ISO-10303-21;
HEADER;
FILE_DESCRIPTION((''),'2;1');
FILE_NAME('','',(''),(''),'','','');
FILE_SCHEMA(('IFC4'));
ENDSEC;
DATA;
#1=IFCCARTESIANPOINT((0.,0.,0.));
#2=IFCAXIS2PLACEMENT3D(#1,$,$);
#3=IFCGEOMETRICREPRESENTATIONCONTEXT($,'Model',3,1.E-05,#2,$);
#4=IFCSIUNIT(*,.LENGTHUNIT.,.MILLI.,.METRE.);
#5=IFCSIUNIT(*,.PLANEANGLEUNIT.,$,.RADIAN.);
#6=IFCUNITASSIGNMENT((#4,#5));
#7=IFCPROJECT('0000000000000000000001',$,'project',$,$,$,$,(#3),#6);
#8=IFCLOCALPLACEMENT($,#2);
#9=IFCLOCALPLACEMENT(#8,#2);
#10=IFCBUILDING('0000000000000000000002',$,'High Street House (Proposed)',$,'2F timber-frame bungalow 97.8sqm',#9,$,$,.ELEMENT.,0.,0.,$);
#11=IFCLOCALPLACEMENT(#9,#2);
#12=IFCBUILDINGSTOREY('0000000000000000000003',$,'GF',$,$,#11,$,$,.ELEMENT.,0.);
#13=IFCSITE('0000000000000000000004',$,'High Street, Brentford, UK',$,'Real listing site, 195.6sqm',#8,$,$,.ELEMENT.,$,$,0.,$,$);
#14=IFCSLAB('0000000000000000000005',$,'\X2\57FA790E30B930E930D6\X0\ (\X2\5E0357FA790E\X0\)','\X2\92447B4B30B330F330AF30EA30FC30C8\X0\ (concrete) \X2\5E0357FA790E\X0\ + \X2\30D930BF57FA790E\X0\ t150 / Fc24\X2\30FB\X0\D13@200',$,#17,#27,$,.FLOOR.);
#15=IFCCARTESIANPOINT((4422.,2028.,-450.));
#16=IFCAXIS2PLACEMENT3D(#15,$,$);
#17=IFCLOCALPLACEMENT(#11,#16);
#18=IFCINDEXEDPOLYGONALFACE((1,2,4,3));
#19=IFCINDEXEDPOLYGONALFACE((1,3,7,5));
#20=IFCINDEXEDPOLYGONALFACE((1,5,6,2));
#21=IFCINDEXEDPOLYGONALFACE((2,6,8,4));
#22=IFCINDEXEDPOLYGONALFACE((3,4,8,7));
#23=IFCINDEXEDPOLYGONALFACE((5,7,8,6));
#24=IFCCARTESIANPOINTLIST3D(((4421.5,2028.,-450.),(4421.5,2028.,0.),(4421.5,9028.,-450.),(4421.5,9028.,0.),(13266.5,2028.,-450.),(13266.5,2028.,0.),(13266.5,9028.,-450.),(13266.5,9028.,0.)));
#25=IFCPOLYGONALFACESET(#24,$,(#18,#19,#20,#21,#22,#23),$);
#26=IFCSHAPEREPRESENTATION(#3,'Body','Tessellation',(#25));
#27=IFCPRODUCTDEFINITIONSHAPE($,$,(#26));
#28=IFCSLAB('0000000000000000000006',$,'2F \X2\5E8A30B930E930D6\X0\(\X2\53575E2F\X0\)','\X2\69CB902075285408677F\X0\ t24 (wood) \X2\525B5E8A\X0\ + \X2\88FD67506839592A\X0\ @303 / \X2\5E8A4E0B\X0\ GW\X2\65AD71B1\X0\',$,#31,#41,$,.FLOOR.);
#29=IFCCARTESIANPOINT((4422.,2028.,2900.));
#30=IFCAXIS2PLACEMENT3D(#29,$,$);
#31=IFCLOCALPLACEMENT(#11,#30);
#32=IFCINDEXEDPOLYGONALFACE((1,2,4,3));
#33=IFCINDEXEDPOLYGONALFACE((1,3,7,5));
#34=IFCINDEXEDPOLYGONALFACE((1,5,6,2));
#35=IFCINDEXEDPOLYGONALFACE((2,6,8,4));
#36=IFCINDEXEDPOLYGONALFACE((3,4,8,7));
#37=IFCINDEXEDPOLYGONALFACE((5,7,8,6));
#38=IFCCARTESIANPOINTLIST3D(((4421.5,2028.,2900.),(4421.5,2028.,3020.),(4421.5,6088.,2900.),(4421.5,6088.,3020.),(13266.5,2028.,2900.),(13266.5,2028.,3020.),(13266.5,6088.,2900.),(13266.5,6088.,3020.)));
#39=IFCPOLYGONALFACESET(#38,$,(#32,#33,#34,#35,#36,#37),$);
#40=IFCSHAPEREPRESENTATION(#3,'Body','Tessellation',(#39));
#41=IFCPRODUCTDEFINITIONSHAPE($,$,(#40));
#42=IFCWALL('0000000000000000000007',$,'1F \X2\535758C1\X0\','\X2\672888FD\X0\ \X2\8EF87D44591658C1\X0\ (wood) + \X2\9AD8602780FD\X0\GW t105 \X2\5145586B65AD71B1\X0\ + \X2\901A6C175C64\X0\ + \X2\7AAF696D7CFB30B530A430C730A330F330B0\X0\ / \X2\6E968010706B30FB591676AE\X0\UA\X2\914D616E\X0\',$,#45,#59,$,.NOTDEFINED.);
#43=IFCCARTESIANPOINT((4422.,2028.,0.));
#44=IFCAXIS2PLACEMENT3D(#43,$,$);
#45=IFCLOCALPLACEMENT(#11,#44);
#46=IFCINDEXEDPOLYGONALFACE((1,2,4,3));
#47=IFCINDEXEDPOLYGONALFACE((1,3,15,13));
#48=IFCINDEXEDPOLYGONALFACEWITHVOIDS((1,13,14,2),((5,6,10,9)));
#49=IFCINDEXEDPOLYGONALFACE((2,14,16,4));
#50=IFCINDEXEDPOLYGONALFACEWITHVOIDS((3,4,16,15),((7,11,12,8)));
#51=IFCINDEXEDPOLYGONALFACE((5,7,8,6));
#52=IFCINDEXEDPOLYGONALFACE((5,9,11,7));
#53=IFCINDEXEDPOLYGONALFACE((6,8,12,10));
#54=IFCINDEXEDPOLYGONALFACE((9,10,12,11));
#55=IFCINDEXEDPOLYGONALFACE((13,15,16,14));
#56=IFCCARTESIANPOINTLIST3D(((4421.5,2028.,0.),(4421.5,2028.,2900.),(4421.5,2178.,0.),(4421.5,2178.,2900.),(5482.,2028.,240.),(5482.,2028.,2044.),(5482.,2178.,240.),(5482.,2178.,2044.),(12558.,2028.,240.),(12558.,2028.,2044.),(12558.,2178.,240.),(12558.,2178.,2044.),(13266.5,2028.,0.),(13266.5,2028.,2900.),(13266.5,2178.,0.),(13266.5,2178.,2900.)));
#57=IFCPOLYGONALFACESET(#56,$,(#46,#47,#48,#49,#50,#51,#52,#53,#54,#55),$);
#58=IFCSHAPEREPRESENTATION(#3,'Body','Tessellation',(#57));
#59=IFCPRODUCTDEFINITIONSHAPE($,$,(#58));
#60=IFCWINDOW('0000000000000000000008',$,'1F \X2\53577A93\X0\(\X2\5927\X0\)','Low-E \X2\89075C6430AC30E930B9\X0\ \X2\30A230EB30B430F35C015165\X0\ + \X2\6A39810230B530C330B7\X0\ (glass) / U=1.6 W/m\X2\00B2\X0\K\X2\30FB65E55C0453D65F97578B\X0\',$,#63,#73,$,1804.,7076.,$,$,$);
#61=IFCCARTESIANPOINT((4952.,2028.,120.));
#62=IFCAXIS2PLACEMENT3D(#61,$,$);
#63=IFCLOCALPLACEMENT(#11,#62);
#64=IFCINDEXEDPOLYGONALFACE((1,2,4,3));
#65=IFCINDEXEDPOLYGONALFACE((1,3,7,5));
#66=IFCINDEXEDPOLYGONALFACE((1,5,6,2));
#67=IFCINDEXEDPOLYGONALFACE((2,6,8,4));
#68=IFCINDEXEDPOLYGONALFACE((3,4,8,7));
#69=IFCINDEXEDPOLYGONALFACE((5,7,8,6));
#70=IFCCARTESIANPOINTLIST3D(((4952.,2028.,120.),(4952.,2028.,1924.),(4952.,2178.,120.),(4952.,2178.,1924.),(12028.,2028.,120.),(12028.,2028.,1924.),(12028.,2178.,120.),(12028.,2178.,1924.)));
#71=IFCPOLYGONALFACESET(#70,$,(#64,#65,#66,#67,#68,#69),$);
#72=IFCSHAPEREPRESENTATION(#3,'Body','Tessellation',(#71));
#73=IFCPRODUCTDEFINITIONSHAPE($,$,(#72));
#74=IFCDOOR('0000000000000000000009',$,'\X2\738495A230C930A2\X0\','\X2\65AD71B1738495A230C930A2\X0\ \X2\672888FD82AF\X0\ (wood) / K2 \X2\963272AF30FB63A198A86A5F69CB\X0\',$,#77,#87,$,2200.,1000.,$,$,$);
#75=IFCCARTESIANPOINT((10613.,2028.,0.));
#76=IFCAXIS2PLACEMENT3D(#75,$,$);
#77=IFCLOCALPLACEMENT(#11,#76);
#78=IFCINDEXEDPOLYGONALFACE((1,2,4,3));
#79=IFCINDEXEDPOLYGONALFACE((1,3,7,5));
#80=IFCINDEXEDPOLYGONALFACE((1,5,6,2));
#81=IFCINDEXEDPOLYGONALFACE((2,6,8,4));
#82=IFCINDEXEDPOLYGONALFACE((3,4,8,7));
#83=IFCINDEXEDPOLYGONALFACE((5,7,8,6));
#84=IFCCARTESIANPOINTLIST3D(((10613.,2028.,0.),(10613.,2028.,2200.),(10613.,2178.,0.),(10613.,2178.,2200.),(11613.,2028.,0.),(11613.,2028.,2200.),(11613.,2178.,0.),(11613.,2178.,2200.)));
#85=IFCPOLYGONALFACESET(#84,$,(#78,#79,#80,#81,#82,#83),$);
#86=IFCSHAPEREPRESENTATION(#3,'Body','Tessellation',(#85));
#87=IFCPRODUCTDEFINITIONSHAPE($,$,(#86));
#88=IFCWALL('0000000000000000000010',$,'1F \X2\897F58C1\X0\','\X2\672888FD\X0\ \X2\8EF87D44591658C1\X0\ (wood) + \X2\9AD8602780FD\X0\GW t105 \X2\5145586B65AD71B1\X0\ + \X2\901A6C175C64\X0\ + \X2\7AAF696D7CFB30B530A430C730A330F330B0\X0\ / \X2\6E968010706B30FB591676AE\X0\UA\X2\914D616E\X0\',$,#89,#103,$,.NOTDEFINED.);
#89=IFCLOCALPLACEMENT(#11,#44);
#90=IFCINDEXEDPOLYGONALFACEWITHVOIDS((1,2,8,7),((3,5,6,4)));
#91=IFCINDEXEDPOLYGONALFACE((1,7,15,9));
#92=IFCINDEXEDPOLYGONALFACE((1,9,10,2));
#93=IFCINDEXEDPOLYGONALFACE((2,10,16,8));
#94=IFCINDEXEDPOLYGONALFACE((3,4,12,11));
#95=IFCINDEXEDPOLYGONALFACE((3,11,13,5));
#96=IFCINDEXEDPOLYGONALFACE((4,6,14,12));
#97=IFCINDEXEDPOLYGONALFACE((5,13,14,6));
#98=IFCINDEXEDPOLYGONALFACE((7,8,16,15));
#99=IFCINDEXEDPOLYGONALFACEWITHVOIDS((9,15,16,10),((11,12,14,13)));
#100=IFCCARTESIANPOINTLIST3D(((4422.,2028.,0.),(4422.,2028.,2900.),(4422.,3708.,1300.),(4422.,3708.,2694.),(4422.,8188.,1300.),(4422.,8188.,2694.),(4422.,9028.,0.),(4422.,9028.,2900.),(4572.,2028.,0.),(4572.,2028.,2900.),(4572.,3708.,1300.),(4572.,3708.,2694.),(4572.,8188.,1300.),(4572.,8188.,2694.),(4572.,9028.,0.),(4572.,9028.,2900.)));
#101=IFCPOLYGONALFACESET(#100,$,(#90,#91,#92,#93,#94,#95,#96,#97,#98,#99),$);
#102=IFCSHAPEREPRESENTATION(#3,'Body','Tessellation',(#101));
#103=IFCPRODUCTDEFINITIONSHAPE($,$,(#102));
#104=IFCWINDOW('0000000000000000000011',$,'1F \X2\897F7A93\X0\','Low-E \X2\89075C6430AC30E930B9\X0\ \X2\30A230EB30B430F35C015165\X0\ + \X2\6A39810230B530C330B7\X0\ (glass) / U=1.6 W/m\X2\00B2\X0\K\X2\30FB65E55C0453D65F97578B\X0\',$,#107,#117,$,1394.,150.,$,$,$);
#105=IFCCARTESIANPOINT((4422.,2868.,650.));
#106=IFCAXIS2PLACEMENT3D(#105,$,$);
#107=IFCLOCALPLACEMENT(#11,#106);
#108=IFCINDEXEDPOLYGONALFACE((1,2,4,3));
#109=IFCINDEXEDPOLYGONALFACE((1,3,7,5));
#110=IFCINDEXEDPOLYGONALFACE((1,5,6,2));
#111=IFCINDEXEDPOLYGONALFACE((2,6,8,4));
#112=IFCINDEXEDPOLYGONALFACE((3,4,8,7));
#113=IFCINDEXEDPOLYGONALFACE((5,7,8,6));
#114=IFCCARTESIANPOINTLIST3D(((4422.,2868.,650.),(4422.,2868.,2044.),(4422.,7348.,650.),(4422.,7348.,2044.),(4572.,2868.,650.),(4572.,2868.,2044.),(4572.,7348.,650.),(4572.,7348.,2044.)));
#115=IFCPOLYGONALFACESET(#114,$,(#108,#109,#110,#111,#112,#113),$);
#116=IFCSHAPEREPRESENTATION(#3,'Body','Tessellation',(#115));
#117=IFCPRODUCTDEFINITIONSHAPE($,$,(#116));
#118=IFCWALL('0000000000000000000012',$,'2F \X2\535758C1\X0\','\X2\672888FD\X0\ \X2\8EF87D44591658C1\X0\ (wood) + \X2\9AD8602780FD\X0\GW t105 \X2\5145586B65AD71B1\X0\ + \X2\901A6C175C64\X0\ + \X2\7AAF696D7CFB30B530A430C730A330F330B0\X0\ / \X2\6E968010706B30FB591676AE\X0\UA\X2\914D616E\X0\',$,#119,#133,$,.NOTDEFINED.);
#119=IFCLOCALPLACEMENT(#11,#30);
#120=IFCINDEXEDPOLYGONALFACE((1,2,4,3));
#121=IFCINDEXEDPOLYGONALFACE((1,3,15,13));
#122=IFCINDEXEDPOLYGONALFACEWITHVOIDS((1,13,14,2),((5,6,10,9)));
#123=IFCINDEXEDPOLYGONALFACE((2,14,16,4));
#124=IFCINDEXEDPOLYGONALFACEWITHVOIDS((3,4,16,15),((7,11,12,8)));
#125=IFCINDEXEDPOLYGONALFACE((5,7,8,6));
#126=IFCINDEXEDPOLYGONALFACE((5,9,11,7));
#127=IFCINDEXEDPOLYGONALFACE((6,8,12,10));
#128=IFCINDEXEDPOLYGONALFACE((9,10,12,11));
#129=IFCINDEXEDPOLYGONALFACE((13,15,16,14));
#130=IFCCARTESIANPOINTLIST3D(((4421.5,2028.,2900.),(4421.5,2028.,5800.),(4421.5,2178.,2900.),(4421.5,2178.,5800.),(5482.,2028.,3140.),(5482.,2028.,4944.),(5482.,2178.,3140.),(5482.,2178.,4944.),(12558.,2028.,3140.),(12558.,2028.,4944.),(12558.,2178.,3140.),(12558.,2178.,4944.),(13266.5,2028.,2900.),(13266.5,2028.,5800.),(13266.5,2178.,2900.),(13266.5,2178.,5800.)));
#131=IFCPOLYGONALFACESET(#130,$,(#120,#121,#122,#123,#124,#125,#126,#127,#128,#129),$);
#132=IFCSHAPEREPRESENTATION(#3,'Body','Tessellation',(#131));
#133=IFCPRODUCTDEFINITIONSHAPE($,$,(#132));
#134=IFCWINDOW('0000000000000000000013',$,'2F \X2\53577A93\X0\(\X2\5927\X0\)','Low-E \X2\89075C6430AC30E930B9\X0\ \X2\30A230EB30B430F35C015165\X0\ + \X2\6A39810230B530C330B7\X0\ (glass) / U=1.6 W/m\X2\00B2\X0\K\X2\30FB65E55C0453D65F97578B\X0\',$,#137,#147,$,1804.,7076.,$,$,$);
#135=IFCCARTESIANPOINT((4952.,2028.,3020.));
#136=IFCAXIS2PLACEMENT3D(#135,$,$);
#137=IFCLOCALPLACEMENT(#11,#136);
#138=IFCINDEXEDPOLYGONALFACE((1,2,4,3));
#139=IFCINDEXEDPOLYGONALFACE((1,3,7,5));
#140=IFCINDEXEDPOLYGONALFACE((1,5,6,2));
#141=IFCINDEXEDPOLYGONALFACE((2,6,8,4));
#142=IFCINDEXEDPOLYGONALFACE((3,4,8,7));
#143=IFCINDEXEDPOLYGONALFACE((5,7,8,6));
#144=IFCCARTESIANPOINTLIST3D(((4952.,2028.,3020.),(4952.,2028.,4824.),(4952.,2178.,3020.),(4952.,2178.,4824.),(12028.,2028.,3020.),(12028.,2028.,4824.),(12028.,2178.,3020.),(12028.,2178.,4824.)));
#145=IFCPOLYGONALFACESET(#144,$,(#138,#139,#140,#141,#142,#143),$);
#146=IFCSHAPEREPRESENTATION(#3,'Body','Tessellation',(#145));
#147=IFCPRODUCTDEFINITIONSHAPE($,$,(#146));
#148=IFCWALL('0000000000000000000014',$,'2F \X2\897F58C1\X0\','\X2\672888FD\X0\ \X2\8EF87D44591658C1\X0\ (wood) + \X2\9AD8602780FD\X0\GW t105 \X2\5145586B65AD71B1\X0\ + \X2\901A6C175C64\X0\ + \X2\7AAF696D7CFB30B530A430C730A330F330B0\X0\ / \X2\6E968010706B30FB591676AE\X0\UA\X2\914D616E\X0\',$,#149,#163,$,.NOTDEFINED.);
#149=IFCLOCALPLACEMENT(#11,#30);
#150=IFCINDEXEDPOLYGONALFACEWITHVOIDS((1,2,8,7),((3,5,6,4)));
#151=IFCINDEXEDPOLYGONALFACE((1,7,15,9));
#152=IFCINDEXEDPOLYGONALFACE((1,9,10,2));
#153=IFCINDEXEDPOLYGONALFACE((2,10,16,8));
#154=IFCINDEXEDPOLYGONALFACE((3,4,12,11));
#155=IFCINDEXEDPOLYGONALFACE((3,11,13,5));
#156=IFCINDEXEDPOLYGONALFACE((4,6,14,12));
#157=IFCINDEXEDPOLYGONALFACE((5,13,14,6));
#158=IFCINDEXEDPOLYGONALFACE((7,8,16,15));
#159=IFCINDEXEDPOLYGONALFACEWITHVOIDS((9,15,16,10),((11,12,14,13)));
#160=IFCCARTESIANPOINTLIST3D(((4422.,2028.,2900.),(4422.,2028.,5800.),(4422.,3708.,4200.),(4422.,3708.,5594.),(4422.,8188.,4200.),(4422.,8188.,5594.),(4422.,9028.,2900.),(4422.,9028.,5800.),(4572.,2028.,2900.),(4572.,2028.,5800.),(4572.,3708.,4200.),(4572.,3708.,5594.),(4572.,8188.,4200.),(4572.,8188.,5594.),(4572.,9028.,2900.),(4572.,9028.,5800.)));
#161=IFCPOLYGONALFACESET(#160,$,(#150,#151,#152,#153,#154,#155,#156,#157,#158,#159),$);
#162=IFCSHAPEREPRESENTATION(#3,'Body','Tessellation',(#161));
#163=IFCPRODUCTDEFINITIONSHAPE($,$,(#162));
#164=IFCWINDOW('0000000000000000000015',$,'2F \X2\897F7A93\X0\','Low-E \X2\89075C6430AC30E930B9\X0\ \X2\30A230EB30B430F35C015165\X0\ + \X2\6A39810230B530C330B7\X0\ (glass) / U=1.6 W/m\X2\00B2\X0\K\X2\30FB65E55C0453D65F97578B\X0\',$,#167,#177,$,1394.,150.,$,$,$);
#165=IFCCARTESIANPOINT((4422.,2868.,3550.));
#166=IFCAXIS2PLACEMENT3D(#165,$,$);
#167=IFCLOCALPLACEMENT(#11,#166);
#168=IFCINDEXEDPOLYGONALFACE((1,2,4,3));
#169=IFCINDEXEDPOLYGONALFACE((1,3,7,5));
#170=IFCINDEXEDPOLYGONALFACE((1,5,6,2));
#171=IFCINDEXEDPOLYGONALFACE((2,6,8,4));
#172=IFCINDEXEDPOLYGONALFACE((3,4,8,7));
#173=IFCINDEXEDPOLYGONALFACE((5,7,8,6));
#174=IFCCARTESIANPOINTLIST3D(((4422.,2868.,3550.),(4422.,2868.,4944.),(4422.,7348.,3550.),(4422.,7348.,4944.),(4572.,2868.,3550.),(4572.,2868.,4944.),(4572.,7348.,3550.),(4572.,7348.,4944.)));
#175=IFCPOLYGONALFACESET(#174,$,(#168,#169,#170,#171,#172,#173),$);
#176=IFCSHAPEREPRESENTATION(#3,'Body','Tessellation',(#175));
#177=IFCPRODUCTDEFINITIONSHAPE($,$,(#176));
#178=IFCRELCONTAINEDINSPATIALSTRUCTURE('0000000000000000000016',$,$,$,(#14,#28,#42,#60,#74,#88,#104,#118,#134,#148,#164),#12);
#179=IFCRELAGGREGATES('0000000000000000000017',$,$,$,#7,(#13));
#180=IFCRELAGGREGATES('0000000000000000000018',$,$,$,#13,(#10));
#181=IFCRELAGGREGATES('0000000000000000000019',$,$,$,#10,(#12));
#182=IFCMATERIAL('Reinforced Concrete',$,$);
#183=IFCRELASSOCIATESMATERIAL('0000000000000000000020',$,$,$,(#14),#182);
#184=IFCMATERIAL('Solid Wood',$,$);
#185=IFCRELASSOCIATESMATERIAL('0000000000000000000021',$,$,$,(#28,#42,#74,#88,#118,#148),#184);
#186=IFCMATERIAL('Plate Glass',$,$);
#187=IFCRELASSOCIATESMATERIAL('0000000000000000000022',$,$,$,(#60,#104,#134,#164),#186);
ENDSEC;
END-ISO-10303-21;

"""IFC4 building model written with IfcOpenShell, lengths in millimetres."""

from ifc_helpers import new_model, si_unit, frame, frame_2d, origin, place, context, project, spatial, rectangle, extrude, material, element, fill, save


model = new_model("IFC4")

# Units and contexts
model_context = context("Model", 3, precision=1e-05, world=origin())
ifc_project = project(units=[si_unit("LENGTHUNIT", "METRE", prefix="MILLI"), si_unit("PLANEANGLEUNIT", "RADIAN")], contexts=[model_context])

# Site, building, storey
site_placement = place(None, origin())
site = spatial("IfcSite", under=ifc_project, at=site_placement, Name="High Street, Brentford, UK", ObjectType="Real listing site, 195.6sqm", CompositionType="ELEMENT", RefElevation=0.0)
building_placement = place(site_placement, origin())
building = spatial("IfcBuilding", under=site, at=building_placement, Name="High Street House (Proposed)", ObjectType="2F timber-frame bungalow 97.8sqm", CompositionType="ELEMENT", ElevationOfRefHeight=0.0, ElevationOfTerrain=0.0)
storey_placement = place(building_placement, origin())
storey = spatial("IfcBuildingStorey", under=building, at=storey_placement, Name="GF", CompositionType="ELEMENT", Elevation=0.0)

# Slabs
ifc_material_1 = material(Name="Reinforced Concrete")
slab_1_placement = place(storey_placement, frame((4422.0, 2028.0, -450.0)))
element("IfcSlab", 1, at=slab_1_placement, inside=storey, material=ifc_material_1, Name="基礎スラブ (布基礎)", Description="鉄筋コンクリート (concrete) 布基礎 + ベタ基礎 t150 / Fc24・D13@200", PredefinedType="FLOOR", context=model_context, shape_type="SweptSolid", body=[
    extrude(rectangle(XDim=8845.0, YDim=7000.0, at=frame_2d((4422.0, 3500.0))), frame((4422.0, 2028.0, -450.0)), (0.0, 0.0, 1.0), 450.0),
])
ifc_material_2 = material(Name="Solid Wood")
slab_2_placement = place(storey_placement, frame((4422.0, 2028.0, 2900.0)))
element("IfcSlab", 2, at=slab_2_placement, inside=storey, material=ifc_material_2, Name="2F 床スラブ(南帯)", Description="構造用合板 t24 (wood) 剛床 + 製材根太 @303 / 床下 GW断熱", PredefinedType="FLOOR", context=model_context, shape_type="SweptSolid", body=[
    extrude(rectangle(XDim=8845.0, YDim=4060.0, at=frame_2d((4422.0, 2030.0))), frame((4422.0, 2028.0, 2900.0)), (0.0, 0.0, 1.0), 120.0),
])

# Wall, openings, window, door
wall_1_placement = place(storey_placement, frame((4422.0, 2028.0, 0.0)))
wall_1 = element("IfcWall", 3, at=wall_1_placement, inside=storey, material=ifc_material_2, Name="1F 南壁", Description="木製 軸組外壁 (wood) + 高性能GW t105 充填断熱 + 通気層 + 窯業系サイディング / 準耐火・外皮UA配慮", PredefinedType="NOTDEFINED", context=model_context, shape_type="SweptSolid", body=[
    extrude(rectangle(XDim=8845.0, YDim=150.0, at=frame_2d((4422.0, 75.0))), frame((4422.0, 2028.0, 0.0)), (0.0, 0.0, 1.0), 2900.0),
])
opening_1_placement = place(storey_placement, frame((4952.0, 2028.0, 120.0)))
opening_1 = element("IfcOpeningElement", 4, at=opening_1_placement, cuts=wall_1, PredefinedType="NOTDEFINED", context=model_context, shape_type="SweptSolid", body=[
    extrude(rectangle(XDim=7076.0, YDim=150.0, at=frame_2d((3538.0, 75.0))), frame((4952.0, 2028.0, 120.0)), (0.0, 0.0, 1.0), 1804.0),
])
opening_2_placement = place(storey_placement, frame((10613.0, 2028.0, 0.0)))
opening_2 = element("IfcOpeningElement", 5, at=opening_2_placement, cuts=wall_1, PredefinedType="NOTDEFINED", context=model_context, shape_type="SweptSolid", body=[
    extrude(rectangle(XDim=1000.0, YDim=150.0, at=frame_2d((500.0, 75.0))), frame((10613.0, 2028.0, 0.0)), (0.0, 0.0, 1.0), 2200.0),
])
ifc_material_3 = material(Name="Plate Glass")
window_1_placement = place(storey_placement, frame((4952.0, 2028.0, 120.0)))
window_1 = element("IfcWindow", 6, at=window_1_placement, inside=storey, material=ifc_material_3, Name="1F 南窓(大)", Description="Low-E 複層ガラス アルゴン封入 + 樹脂サッシ (glass) / U=1.6 W/m²K・日射取得型", OverallHeight=1804.0, OverallWidth=7076.0, context=model_context, shape_type="SweptSolid", body=[
    extrude(rectangle(XDim=7076.0, YDim=150.0, at=frame_2d((3538.0, 75.0))), frame((4952.0, 2028.0, 120.0)), (0.0, 0.0, 1.0), 1804.0),
])
fill(opening_1, window_1)
door_placement = place(storey_placement, frame((10613.0, 2028.0, 0.0)))
door = element("IfcDoor", 7, at=door_placement, inside=storey, material=ifc_material_2, Name="玄関ドア", Description="断熱玄関ドア 木製芯 (wood) / K2 防犯・採風機構", OverallHeight=2200.0, OverallWidth=1000.0, context=model_context, shape_type="SweptSolid", body=[
    extrude(rectangle(XDim=1000.0, YDim=150.0, at=frame_2d((500.0, 75.0))), frame((10613.0, 2028.0, 0.0)), (0.0, 0.0, 1.0), 2200.0),
])
fill(opening_2, door)

# Wall, opening, window
wall_2_placement = place(storey_placement, frame((4422.0, 2028.0, 0.0)))
wall_2 = element("IfcWall", 8, at=wall_2_placement, inside=storey, material=ifc_material_2, Name="1F 西壁", Description="木製 軸組外壁 (wood) + 高性能GW t105 充填断熱 + 通気層 + 窯業系サイディング / 準耐火・外皮UA配慮", PredefinedType="NOTDEFINED", context=model_context, shape_type="SweptSolid", body=[
    extrude(rectangle(XDim=150.0, YDim=7000.0, at=frame_2d((75.0, 3500.0))), frame((4422.0, 2028.0, 0.0)), (0.0, 0.0, 1.0), 2900.0),
])
opening_3_placement = place(storey_placement, frame((4422.0, 2868.0, 650.0)))
opening_3 = element("IfcOpeningElement", 9, at=opening_3_placement, cuts=wall_2, PredefinedType="NOTDEFINED", context=model_context, shape_type="SweptSolid", body=[
    extrude(rectangle(XDim=150.0, YDim=4480.0, at=frame_2d((75.0, 2240.0))), frame((4422.0, 2868.0, 650.0)), (0.0, 0.0, 1.0), 1394.0),
])
window_2_placement = place(storey_placement, frame((4422.0, 2868.0, 650.0)))
window_2 = element("IfcWindow", 10, at=window_2_placement, inside=storey, material=ifc_material_3, Name="1F 西窓", Description="Low-E 複層ガラス アルゴン封入 + 樹脂サッシ (glass) / U=1.6 W/m²K・日射取得型", OverallHeight=1394.0, OverallWidth=150.0, context=model_context, shape_type="SweptSolid", body=[
    extrude(rectangle(XDim=150.0, YDim=4480.0, at=frame_2d((75.0, 2240.0))), frame((4422.0, 2868.0, 650.0)), (0.0, 0.0, 1.0), 1394.0),
])
fill(opening_3, window_2)

# Walls, openings, windows
wall_3_placement = place(storey_placement, frame((4422.0, 2028.0, 2900.0)))
wall_3 = element("IfcWall", 11, at=wall_3_placement, inside=storey, material=ifc_material_2, Name="2F 南壁", Description="木製 軸組外壁 (wood) + 高性能GW t105 充填断熱 + 通気層 + 窯業系サイディング / 準耐火・外皮UA配慮", PredefinedType="NOTDEFINED", context=model_context, shape_type="SweptSolid", body=[
    extrude(rectangle(XDim=8845.0, YDim=150.0, at=frame_2d((4422.0, 75.0))), frame((4422.0, 2028.0, 2900.0)), (0.0, 0.0, 1.0), 2900.0),
])
opening_4_placement = place(storey_placement, frame((4952.0, 2028.0, 3020.0)))
opening_4 = element("IfcOpeningElement", 12, at=opening_4_placement, cuts=wall_3, PredefinedType="NOTDEFINED", context=model_context, shape_type="SweptSolid", body=[
    extrude(rectangle(XDim=7076.0, YDim=150.0, at=frame_2d((3538.0, 75.0))), frame((4952.0, 2028.0, 3020.0)), (0.0, 0.0, 1.0), 1804.0),
])
window_3_placement = place(storey_placement, frame((4952.0, 2028.0, 3020.0)))
window_3 = element("IfcWindow", 13, at=window_3_placement, inside=storey, material=ifc_material_3, Name="2F 南窓(大)", Description="Low-E 複層ガラス アルゴン封入 + 樹脂サッシ (glass) / U=1.6 W/m²K・日射取得型", OverallHeight=1804.0, OverallWidth=7076.0, context=model_context, shape_type="SweptSolid", body=[
    extrude(rectangle(XDim=7076.0, YDim=150.0, at=frame_2d((3538.0, 75.0))), frame((4952.0, 2028.0, 3020.0)), (0.0, 0.0, 1.0), 1804.0),
])
fill(opening_4, window_3)
wall_4_placement = place(storey_placement, frame((4422.0, 2028.0, 2900.0)))
wall_4 = element("IfcWall", 14, at=wall_4_placement, inside=storey, material=ifc_material_2, Name="2F 西壁", Description="木製 軸組外壁 (wood) + 高性能GW t105 充填断熱 + 通気層 + 窯業系サイディング / 準耐火・外皮UA配慮", PredefinedType="NOTDEFINED", context=model_context, shape_type="SweptSolid", body=[
    extrude(rectangle(XDim=150.0, YDim=7000.0, at=frame_2d((75.0, 3500.0))), frame((4422.0, 2028.0, 2900.0)), (0.0, 0.0, 1.0), 2900.0),
])
opening_5_placement = place(storey_placement, frame((4422.0, 2868.0, 3550.0)))
opening_5 = element("IfcOpeningElement", 15, at=opening_5_placement, cuts=wall_4, PredefinedType="NOTDEFINED", context=model_context, shape_type="SweptSolid", body=[
    extrude(rectangle(XDim=150.0, YDim=4480.0, at=frame_2d((75.0, 2240.0))), frame((4422.0, 2868.0, 3550.0)), (0.0, 0.0, 1.0), 1394.0),
])
window_4_placement = place(storey_placement, frame((4422.0, 2868.0, 3550.0)))
window_4 = element("IfcWindow", 16, at=window_4_placement, inside=storey, material=ifc_material_3, Name="2F 西窓", Description="Low-E 複層ガラス アルゴン封入 + 樹脂サッシ (glass) / U=1.6 W/m²K・日射取得型", OverallHeight=1394.0, OverallWidth=150.0, context=model_context, shape_type="SweptSolid", body=[
    extrude(rectangle(XDim=150.0, YDim=4480.0, at=frame_2d((75.0, 2240.0))), frame((4422.0, 2868.0, 3550.0)), (0.0, 0.0, 1.0), 1394.0),
])
fill(opening_5, window_4)

save(model, "model.ifc")
